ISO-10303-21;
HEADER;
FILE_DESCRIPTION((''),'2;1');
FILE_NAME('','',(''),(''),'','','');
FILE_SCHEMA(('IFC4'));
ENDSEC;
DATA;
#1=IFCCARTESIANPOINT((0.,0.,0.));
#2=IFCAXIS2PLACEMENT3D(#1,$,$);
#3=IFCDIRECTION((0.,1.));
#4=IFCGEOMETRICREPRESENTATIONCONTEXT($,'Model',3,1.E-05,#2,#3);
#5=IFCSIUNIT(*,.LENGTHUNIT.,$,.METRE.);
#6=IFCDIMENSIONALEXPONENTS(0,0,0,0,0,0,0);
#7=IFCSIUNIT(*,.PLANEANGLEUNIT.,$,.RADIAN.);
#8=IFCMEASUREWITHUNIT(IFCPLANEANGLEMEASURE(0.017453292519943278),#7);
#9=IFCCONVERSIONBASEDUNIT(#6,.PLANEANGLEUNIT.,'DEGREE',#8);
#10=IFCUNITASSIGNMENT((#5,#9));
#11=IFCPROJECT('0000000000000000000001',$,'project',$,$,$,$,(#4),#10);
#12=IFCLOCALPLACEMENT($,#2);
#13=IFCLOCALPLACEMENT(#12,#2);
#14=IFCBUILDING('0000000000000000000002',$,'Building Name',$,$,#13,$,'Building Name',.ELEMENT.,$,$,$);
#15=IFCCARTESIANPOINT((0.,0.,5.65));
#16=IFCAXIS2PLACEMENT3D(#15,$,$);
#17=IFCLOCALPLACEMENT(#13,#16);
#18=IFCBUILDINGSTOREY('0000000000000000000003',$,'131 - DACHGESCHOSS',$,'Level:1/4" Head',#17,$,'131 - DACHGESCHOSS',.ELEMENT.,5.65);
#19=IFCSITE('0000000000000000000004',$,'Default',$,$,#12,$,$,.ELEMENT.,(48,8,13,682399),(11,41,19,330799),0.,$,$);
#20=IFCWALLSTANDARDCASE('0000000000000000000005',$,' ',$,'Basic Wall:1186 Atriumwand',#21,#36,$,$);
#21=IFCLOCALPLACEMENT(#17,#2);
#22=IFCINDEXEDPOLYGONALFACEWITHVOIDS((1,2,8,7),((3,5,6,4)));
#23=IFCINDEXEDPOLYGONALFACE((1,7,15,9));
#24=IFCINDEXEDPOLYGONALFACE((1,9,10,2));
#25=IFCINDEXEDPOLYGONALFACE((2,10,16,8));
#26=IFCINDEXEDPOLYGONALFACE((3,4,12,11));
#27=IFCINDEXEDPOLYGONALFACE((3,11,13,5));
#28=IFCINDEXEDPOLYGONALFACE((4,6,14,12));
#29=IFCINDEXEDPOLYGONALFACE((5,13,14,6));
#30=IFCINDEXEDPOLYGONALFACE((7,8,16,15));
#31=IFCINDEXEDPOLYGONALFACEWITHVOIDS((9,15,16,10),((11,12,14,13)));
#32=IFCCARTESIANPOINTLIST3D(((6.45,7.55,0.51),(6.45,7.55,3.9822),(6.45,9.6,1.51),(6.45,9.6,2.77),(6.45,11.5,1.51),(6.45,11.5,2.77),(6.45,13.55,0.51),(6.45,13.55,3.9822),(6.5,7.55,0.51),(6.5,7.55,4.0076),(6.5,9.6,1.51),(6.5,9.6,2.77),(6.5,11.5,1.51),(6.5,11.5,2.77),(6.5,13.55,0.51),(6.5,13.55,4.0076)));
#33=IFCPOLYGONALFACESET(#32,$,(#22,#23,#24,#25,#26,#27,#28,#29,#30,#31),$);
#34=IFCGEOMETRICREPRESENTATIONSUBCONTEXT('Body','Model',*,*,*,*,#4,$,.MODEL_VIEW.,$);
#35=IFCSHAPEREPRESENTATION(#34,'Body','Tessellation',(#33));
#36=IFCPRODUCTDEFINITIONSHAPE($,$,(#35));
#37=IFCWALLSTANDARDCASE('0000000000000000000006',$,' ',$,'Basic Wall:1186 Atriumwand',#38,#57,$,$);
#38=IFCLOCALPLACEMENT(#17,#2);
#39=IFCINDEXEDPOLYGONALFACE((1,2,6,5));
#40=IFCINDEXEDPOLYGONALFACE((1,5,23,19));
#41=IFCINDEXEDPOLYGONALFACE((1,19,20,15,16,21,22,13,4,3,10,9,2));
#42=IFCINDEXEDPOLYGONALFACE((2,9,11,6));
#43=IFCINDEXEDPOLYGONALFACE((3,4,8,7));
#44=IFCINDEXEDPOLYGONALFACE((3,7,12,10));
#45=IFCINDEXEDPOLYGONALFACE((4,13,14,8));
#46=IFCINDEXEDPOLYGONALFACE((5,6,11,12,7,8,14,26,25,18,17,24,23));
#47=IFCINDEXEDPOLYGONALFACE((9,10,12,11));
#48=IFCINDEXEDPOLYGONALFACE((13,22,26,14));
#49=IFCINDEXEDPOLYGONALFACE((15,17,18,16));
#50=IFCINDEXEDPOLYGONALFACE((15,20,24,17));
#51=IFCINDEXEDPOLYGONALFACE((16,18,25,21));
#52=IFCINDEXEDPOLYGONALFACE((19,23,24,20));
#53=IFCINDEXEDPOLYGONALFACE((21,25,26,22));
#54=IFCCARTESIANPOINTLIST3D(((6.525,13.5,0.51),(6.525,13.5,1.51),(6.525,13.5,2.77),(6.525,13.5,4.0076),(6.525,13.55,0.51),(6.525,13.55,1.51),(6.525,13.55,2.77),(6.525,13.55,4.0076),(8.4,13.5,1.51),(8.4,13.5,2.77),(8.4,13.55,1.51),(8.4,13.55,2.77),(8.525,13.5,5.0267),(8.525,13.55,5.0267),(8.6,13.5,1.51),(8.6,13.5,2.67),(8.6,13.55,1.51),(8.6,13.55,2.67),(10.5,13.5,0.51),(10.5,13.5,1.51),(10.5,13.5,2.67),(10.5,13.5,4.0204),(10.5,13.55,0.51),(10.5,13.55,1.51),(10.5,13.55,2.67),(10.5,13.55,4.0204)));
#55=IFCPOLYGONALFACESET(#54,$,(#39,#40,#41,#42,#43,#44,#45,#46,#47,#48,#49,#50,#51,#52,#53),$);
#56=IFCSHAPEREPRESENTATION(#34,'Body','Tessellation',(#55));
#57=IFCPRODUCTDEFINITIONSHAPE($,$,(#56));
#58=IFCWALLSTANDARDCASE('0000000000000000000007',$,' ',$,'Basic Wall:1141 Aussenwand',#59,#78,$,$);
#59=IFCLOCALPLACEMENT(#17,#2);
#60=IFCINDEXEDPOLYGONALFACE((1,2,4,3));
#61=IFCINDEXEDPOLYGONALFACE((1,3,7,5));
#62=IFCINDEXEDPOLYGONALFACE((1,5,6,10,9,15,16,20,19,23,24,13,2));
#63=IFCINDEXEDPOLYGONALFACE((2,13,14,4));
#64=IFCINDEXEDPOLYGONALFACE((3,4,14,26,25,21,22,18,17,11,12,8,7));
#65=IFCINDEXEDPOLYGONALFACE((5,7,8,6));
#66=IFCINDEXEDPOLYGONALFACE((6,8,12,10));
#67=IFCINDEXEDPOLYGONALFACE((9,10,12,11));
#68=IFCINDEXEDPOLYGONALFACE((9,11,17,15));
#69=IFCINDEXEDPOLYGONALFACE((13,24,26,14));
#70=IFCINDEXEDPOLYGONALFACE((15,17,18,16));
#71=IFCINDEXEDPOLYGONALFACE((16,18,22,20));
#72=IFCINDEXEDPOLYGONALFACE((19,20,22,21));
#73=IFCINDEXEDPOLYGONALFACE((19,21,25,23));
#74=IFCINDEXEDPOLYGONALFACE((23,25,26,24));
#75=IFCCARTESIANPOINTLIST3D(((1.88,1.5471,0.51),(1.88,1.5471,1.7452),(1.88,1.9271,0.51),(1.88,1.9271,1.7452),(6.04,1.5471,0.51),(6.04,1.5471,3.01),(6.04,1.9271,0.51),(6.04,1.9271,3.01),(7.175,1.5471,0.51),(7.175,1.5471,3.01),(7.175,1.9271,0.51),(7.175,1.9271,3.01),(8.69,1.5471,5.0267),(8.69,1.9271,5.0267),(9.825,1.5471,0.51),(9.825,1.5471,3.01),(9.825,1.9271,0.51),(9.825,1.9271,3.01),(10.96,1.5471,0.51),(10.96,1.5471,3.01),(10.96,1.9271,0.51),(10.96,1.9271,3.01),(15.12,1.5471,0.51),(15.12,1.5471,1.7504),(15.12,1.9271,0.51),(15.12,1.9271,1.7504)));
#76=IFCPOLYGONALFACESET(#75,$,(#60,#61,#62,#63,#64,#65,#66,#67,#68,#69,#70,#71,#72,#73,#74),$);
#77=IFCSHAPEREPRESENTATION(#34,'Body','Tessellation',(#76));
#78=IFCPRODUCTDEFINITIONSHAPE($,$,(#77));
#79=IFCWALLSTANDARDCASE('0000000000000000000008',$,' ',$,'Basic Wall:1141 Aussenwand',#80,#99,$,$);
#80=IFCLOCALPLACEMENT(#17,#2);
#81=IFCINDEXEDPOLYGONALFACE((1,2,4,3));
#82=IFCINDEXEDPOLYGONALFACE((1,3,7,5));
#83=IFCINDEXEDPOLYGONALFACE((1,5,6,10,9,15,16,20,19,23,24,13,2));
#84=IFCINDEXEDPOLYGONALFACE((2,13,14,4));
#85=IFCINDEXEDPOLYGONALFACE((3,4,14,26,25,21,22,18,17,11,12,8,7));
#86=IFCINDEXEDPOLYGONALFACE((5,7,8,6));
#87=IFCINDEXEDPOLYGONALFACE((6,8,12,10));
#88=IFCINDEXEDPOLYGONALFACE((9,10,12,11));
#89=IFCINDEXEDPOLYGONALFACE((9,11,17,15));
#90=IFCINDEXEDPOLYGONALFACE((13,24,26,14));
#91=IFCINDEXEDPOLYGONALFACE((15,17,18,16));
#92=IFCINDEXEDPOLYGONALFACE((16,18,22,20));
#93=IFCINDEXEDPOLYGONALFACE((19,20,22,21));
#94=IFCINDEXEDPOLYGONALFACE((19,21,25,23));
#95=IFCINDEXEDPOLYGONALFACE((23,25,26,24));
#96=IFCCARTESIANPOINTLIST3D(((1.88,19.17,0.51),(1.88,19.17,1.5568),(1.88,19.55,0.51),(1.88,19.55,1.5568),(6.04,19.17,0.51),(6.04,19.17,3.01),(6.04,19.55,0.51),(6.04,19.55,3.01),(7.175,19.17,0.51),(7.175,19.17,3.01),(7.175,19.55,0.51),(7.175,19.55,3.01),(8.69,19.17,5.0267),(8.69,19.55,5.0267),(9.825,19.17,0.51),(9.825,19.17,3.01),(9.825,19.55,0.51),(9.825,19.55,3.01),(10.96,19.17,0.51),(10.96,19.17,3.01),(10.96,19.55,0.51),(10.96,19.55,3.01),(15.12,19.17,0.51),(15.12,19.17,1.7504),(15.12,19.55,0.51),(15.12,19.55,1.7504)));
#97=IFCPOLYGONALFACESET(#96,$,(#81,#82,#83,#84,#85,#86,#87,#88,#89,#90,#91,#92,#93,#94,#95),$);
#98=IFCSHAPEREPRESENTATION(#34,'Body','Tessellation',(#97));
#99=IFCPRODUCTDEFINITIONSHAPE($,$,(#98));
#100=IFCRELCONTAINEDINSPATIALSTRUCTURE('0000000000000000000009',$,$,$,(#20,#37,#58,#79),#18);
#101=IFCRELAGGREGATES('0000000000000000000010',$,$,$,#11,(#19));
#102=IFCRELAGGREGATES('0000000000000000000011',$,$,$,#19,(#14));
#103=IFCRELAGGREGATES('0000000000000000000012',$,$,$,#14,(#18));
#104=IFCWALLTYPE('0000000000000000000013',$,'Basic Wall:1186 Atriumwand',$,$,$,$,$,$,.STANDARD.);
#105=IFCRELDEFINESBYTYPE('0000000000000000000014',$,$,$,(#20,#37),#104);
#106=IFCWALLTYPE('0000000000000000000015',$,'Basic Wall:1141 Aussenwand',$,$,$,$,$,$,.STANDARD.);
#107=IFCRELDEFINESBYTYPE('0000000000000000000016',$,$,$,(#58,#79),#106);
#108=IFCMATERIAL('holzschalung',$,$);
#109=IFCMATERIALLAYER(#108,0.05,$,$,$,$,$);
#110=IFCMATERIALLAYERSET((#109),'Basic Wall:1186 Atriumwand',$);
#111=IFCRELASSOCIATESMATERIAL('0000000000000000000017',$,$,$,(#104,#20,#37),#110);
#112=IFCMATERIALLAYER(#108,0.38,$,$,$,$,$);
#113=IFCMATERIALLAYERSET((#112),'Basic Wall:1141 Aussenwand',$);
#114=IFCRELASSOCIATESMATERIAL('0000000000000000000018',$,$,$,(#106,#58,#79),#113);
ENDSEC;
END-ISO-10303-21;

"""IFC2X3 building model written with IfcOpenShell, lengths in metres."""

from ifc_helpers import new_model, entity, si_unit, converted_unit, direction, frame, frame_2d, origin, place, context, subcontext, project, spatial, rectangle, extrude, clip, halfspace, material, layer, layer_set, layer_usage, type_object, element, save


model = new_model("IFC2X3")

# Units and contexts
model_context = context("Model", 3, precision=1e-05, world=origin(), true_north=direction((0.0, 1.0)))
body_context = subcontext(model_context, "Body", "Model", "MODEL_VIEW")
ifc_project = project(units=[si_unit("LENGTHUNIT", "METRE"), converted_unit("PLANEANGLEUNIT", "DEGREE", entity("IfcPlaneAngleMeasure", 0.017453292519943278), si_unit("PLANEANGLEUNIT", "RADIAN"), dimensions=[0, 0, 0, 0, 0, 0, 0])], contexts=[model_context])

# Site, building, storey
site_placement = place(None, origin())
site = spatial("IfcSite", under=ifc_project, at=site_placement, Name="Default", CompositionType="ELEMENT", RefLatitude=(48, 8, 13, 682399), RefLongitude=(11, 41, 19, 330799), RefElevation=0.0)
building_placement = place(site_placement, origin())
building = spatial("IfcBuilding", under=site, at=building_placement, Name="Building Name", LongName="Building Name", CompositionType="ELEMENT")
storey_placement = place(building_placement, frame((0.0, 0.0, 5.65)))
storey = spatial("IfcBuildingStorey", under=building, at=storey_placement, Name="131 - DACHGESCHOSS", ObjectType="Level:1/4\" Head", LongName="131 - DACHGESCHOSS", CompositionType="ELEMENT", Elevation=5.65)

# Shared definitions
ifc_material = material(Name="holzschalung")

# Walls, openings
ifc_layer_1 = layer(ifc_material, 0.05)
ifc_layer_set_1 = layer_set([ifc_layer_1], Name="Basic Wall:1186 Atriumwand")
ifc_layer_usage_1 = layer_usage(ifc_layer_set_1, "AXIS2", "NEGATIVE", 0.025)
wall_type_1 = type_object("IfcWallType", Name="Basic Wall:1186 Atriumwand", PredefinedType="STANDARD", material=ifc_layer_set_1)
wall_1_placement = place(storey_placement, frame((6.475, 7.55, 0.51), z_axis=(0.0, 0.0, 1.0), x_axis=(0.0, 1.0, 0.0)))
wall_1 = element("IfcWallStandardCase", 1, at=wall_1_placement, inside=storey, type_object=wall_type_1, material=ifc_layer_usage_1, Name=" ", ObjectType="Basic Wall:1186 Atriumwand", context=body_context, shape_type="SweptSolid", body=[
    extrude(rectangle(XDim=6.0, YDim=0.05, at=frame_2d((3.0, 0.0), x_axis=(-1.0, 0.0))), origin(), (0.0, 0.0, 1.0), 3.4976),
])
opening_1_placement = place(wall_1_placement, origin())
element("IfcOpeningElement", 2, at=opening_1_placement, cuts=wall_1, ObjectType="Opening", context=body_context, shape_type="SweptSolid", body=[
    extrude(rectangle(XDim=6.9075, YDim=13.815, at=frame_2d((0.0, 0.0), x_axis=(1.0, 0.0))), frame((3.0, -3.177, 8.9799), z_axis=(0.0, 0.891007, -0.45399), x_axis=(0.0, -0.45399, -0.891007)), (0.0, 0.0, 1.0), 13.815),
])
opening_2_placement = place(wall_1_placement, origin())
element("IfcOpeningElement", 3, at=opening_2_placement, cuts=wall_1, ObjectType="Opening", context=body_context, shape_type="SweptSolid", body=[
    extrude(rectangle(XDim=1.26, YDim=1.9, at=frame_2d((0.0, 0.0), x_axis=(0.0, 1.0))), frame((3.0, -0.025, 1.63), z_axis=(0.0, 1.0, 0.0), x_axis=(-1.0, 0.0, 0.0)), (0.0, 0.0, 1.0), 0.05),
])
ifc_layer_usage_2 = layer_usage(ifc_layer_set_1, "AXIS2", "NEGATIVE", 0.025)
wall_2_placement = place(storey_placement, frame((6.525, 13.525, 0.51)))
wall_2 = element("IfcWallStandardCase", 4, at=wall_2_placement, inside=storey, type_object=wall_type_1, material=ifc_layer_usage_2, Name=" ", ObjectType="Basic Wall:1186 Atriumwand", context=body_context, shape_type="Clipping", body=[
    clip(clip(extrude(rectangle(XDim=3.975, YDim=0.05, at=frame_2d((1.9875, 0.0), x_axis=(-1.0, 0.0))), origin(), (0.0, 0.0, 1.0), 4.5167), halfspace(frame((0.0, -0.025, 3.4976), z_axis=(-0.45399, 0.0, 0.891007), x_axis=(0.0, 1.0, 0.0)), False)), halfspace(frame((2.0, -0.025, 4.5167), z_axis=(0.45399, 0.0, 0.891007), x_axis=(0.0, 1.0, 0.0)), False)),
])
opening_3_placement = place(wall_2_placement, origin())
element("IfcOpeningElement", 5, at=opening_3_placement, cuts=wall_2, ObjectType="Opening", context=body_context, shape_type="SweptSolid", body=[
    extrude(rectangle(XDim=1.26, YDim=1.9, at=frame_2d((0.0, 0.0), x_axis=(0.0, 1.0))), frame((0.925, -0.025, 1.63), z_axis=(0.0, 1.0, 0.0), x_axis=(-1.0, 0.0, 0.0)), (0.0, 0.0, 1.0), 0.05),
])
opening_4_placement = place(wall_2_placement, origin())
element("IfcOpeningElement", 6, at=opening_4_placement, cuts=wall_2, ObjectType="Opening", context=body_context, shape_type="SweptSolid", body=[
    extrude(rectangle(XDim=1.16, YDim=1.9, at=frame_2d((0.0, 0.0), x_axis=(0.0, 1.0))), frame((3.025, -0.025, 1.58), z_axis=(0.0, 1.0, 0.0), x_axis=(-1.0, 0.0, 0.0)), (0.0, 0.0, 1.0), 0.05),
])

# Shared definitions
ifc_layer_2 = layer(ifc_material, 0.38)
ifc_layer_set_2 = layer_set([ifc_layer_2], Name="Basic Wall:1141 Aussenwand")
wall_type_2 = type_object("IfcWallType", Name="Basic Wall:1141 Aussenwand", PredefinedType="STANDARD", material=ifc_layer_set_2)

# Walls, openings
ifc_layer_usage_3 = layer_usage(ifc_layer_set_2, "AXIS2", "NEGATIVE", 0.19)
wall_3_placement = place(storey_placement, frame((15.12, 1.7371, 0.51), z_axis=(0.0, 0.0, 1.0), x_axis=(-1.0, 0.0, 0.0)))
wall_3 = element("IfcWallStandardCase", 7, at=wall_3_placement, inside=storey, type_object=wall_type_2, material=ifc_layer_usage_3, Name=" ", ObjectType="Basic Wall:1141 Aussenwand", context=body_context, shape_type="Clipping", body=[
    clip(clip(extrude(rectangle(XDim=13.24, YDim=0.38, at=frame_2d((6.62, 0.0), x_axis=(-1.0, 0.0))), origin(), (0.0, 0.0, 1.0), 4.5167), halfspace(frame((0.0, -0.19, 1.2404), z_axis=(-0.45399, 0.0, 0.891007), x_axis=(0.0, 1.0, 0.0)), False)), halfspace(frame((6.43, -0.19, 4.5167), z_axis=(0.434096, 0.0, 0.900866), x_axis=(0.0, 1.0, 0.0)), False)),
])
opening_5_placement = place(wall_3_placement, origin())
element("IfcOpeningElement", 8, at=opening_5_placement, cuts=wall_3, ObjectType="Opening", context=body_context, shape_type="SweptSolid", body=[
    extrude(rectangle(XDim=2.5, YDim=1.135, at=frame_2d((0.0, 0.0), x_axis=(1.0, 0.0))), frame((4.7275, -0.19, 1.25), z_axis=(0.0, 1.0, 0.0), x_axis=(0.0, 0.0, 1.0)), (0.0, 0.0, 1.0), 0.38),
])
opening_6_placement = place(wall_3_placement, origin())
element("IfcOpeningElement", 9, at=opening_6_placement, cuts=wall_3, ObjectType="Opening", context=body_context, shape_type="SweptSolid", body=[
    extrude(rectangle(XDim=2.5, YDim=1.135, at=frame_2d((0.0, 0.0), x_axis=(1.0, 0.0))), frame((8.5125, -0.19, 1.25), z_axis=(0.0, 1.0, 0.0), x_axis=(0.0, 0.0, 1.0)), (0.0, 0.0, 1.0), 0.38),
])
ifc_layer_usage_4 = layer_usage(ifc_layer_set_2, "AXIS2", "NEGATIVE", 0.19)
wall_4_placement = place(storey_placement, frame((1.88, 19.36, 0.51)))
wall_4 = element("IfcWallStandardCase", 10, at=wall_4_placement, inside=storey, type_object=wall_type_2, material=ifc_layer_usage_4, Name=" ", ObjectType="Basic Wall:1141 Aussenwand", context=body_context, shape_type="Clipping", body=[
    clip(clip(extrude(rectangle(XDim=13.24, YDim=0.38, at=frame_2d((6.62, 0.0), x_axis=(-1.0, 0.0))), origin(), (0.0, 0.0, 1.0), 4.5167), halfspace(frame((0.0, -0.19, 1.0468), z_axis=(-0.45399, 0.0, 0.891007), x_axis=(0.0, 1.0, 0.0)), False)), halfspace(frame((6.81, -0.19, 4.5167), z_axis=(0.45399, 0.0, 0.891007), x_axis=(0.0, 1.0, 0.0)), False)),
])
opening_7_placement = place(wall_4_placement, origin())
element("IfcOpeningElement", 11, at=opening_7_placement, cuts=wall_4, ObjectType="Opening", context=body_context, shape_type="SweptSolid", body=[
    extrude(rectangle(XDim=2.5, YDim=1.135, at=frame_2d((0.0, 0.0), x_axis=(1.0, 0.0))), frame((8.5125, -0.19, 1.25), z_axis=(0.0, 1.0, 0.0), x_axis=(0.0, 0.0, 1.0)), (0.0, 0.0, 1.0), 0.38),
])
opening_8_placement = place(wall_4_placement, origin())
element("IfcOpeningElement", 12, at=opening_8_placement, cuts=wall_4, ObjectType="Opening", context=body_context, shape_type="SweptSolid", body=[
    extrude(rectangle(XDim=2.5, YDim=1.135, at=frame_2d((0.0, 0.0), x_axis=(1.0, 0.0))), frame((4.7275, -0.19, 1.25), z_axis=(0.0, 1.0, 0.0), x_axis=(0.0, 0.0, 1.0)), (0.0, 0.0, 1.0), 0.38),
])

save(model, "model.ifc")
